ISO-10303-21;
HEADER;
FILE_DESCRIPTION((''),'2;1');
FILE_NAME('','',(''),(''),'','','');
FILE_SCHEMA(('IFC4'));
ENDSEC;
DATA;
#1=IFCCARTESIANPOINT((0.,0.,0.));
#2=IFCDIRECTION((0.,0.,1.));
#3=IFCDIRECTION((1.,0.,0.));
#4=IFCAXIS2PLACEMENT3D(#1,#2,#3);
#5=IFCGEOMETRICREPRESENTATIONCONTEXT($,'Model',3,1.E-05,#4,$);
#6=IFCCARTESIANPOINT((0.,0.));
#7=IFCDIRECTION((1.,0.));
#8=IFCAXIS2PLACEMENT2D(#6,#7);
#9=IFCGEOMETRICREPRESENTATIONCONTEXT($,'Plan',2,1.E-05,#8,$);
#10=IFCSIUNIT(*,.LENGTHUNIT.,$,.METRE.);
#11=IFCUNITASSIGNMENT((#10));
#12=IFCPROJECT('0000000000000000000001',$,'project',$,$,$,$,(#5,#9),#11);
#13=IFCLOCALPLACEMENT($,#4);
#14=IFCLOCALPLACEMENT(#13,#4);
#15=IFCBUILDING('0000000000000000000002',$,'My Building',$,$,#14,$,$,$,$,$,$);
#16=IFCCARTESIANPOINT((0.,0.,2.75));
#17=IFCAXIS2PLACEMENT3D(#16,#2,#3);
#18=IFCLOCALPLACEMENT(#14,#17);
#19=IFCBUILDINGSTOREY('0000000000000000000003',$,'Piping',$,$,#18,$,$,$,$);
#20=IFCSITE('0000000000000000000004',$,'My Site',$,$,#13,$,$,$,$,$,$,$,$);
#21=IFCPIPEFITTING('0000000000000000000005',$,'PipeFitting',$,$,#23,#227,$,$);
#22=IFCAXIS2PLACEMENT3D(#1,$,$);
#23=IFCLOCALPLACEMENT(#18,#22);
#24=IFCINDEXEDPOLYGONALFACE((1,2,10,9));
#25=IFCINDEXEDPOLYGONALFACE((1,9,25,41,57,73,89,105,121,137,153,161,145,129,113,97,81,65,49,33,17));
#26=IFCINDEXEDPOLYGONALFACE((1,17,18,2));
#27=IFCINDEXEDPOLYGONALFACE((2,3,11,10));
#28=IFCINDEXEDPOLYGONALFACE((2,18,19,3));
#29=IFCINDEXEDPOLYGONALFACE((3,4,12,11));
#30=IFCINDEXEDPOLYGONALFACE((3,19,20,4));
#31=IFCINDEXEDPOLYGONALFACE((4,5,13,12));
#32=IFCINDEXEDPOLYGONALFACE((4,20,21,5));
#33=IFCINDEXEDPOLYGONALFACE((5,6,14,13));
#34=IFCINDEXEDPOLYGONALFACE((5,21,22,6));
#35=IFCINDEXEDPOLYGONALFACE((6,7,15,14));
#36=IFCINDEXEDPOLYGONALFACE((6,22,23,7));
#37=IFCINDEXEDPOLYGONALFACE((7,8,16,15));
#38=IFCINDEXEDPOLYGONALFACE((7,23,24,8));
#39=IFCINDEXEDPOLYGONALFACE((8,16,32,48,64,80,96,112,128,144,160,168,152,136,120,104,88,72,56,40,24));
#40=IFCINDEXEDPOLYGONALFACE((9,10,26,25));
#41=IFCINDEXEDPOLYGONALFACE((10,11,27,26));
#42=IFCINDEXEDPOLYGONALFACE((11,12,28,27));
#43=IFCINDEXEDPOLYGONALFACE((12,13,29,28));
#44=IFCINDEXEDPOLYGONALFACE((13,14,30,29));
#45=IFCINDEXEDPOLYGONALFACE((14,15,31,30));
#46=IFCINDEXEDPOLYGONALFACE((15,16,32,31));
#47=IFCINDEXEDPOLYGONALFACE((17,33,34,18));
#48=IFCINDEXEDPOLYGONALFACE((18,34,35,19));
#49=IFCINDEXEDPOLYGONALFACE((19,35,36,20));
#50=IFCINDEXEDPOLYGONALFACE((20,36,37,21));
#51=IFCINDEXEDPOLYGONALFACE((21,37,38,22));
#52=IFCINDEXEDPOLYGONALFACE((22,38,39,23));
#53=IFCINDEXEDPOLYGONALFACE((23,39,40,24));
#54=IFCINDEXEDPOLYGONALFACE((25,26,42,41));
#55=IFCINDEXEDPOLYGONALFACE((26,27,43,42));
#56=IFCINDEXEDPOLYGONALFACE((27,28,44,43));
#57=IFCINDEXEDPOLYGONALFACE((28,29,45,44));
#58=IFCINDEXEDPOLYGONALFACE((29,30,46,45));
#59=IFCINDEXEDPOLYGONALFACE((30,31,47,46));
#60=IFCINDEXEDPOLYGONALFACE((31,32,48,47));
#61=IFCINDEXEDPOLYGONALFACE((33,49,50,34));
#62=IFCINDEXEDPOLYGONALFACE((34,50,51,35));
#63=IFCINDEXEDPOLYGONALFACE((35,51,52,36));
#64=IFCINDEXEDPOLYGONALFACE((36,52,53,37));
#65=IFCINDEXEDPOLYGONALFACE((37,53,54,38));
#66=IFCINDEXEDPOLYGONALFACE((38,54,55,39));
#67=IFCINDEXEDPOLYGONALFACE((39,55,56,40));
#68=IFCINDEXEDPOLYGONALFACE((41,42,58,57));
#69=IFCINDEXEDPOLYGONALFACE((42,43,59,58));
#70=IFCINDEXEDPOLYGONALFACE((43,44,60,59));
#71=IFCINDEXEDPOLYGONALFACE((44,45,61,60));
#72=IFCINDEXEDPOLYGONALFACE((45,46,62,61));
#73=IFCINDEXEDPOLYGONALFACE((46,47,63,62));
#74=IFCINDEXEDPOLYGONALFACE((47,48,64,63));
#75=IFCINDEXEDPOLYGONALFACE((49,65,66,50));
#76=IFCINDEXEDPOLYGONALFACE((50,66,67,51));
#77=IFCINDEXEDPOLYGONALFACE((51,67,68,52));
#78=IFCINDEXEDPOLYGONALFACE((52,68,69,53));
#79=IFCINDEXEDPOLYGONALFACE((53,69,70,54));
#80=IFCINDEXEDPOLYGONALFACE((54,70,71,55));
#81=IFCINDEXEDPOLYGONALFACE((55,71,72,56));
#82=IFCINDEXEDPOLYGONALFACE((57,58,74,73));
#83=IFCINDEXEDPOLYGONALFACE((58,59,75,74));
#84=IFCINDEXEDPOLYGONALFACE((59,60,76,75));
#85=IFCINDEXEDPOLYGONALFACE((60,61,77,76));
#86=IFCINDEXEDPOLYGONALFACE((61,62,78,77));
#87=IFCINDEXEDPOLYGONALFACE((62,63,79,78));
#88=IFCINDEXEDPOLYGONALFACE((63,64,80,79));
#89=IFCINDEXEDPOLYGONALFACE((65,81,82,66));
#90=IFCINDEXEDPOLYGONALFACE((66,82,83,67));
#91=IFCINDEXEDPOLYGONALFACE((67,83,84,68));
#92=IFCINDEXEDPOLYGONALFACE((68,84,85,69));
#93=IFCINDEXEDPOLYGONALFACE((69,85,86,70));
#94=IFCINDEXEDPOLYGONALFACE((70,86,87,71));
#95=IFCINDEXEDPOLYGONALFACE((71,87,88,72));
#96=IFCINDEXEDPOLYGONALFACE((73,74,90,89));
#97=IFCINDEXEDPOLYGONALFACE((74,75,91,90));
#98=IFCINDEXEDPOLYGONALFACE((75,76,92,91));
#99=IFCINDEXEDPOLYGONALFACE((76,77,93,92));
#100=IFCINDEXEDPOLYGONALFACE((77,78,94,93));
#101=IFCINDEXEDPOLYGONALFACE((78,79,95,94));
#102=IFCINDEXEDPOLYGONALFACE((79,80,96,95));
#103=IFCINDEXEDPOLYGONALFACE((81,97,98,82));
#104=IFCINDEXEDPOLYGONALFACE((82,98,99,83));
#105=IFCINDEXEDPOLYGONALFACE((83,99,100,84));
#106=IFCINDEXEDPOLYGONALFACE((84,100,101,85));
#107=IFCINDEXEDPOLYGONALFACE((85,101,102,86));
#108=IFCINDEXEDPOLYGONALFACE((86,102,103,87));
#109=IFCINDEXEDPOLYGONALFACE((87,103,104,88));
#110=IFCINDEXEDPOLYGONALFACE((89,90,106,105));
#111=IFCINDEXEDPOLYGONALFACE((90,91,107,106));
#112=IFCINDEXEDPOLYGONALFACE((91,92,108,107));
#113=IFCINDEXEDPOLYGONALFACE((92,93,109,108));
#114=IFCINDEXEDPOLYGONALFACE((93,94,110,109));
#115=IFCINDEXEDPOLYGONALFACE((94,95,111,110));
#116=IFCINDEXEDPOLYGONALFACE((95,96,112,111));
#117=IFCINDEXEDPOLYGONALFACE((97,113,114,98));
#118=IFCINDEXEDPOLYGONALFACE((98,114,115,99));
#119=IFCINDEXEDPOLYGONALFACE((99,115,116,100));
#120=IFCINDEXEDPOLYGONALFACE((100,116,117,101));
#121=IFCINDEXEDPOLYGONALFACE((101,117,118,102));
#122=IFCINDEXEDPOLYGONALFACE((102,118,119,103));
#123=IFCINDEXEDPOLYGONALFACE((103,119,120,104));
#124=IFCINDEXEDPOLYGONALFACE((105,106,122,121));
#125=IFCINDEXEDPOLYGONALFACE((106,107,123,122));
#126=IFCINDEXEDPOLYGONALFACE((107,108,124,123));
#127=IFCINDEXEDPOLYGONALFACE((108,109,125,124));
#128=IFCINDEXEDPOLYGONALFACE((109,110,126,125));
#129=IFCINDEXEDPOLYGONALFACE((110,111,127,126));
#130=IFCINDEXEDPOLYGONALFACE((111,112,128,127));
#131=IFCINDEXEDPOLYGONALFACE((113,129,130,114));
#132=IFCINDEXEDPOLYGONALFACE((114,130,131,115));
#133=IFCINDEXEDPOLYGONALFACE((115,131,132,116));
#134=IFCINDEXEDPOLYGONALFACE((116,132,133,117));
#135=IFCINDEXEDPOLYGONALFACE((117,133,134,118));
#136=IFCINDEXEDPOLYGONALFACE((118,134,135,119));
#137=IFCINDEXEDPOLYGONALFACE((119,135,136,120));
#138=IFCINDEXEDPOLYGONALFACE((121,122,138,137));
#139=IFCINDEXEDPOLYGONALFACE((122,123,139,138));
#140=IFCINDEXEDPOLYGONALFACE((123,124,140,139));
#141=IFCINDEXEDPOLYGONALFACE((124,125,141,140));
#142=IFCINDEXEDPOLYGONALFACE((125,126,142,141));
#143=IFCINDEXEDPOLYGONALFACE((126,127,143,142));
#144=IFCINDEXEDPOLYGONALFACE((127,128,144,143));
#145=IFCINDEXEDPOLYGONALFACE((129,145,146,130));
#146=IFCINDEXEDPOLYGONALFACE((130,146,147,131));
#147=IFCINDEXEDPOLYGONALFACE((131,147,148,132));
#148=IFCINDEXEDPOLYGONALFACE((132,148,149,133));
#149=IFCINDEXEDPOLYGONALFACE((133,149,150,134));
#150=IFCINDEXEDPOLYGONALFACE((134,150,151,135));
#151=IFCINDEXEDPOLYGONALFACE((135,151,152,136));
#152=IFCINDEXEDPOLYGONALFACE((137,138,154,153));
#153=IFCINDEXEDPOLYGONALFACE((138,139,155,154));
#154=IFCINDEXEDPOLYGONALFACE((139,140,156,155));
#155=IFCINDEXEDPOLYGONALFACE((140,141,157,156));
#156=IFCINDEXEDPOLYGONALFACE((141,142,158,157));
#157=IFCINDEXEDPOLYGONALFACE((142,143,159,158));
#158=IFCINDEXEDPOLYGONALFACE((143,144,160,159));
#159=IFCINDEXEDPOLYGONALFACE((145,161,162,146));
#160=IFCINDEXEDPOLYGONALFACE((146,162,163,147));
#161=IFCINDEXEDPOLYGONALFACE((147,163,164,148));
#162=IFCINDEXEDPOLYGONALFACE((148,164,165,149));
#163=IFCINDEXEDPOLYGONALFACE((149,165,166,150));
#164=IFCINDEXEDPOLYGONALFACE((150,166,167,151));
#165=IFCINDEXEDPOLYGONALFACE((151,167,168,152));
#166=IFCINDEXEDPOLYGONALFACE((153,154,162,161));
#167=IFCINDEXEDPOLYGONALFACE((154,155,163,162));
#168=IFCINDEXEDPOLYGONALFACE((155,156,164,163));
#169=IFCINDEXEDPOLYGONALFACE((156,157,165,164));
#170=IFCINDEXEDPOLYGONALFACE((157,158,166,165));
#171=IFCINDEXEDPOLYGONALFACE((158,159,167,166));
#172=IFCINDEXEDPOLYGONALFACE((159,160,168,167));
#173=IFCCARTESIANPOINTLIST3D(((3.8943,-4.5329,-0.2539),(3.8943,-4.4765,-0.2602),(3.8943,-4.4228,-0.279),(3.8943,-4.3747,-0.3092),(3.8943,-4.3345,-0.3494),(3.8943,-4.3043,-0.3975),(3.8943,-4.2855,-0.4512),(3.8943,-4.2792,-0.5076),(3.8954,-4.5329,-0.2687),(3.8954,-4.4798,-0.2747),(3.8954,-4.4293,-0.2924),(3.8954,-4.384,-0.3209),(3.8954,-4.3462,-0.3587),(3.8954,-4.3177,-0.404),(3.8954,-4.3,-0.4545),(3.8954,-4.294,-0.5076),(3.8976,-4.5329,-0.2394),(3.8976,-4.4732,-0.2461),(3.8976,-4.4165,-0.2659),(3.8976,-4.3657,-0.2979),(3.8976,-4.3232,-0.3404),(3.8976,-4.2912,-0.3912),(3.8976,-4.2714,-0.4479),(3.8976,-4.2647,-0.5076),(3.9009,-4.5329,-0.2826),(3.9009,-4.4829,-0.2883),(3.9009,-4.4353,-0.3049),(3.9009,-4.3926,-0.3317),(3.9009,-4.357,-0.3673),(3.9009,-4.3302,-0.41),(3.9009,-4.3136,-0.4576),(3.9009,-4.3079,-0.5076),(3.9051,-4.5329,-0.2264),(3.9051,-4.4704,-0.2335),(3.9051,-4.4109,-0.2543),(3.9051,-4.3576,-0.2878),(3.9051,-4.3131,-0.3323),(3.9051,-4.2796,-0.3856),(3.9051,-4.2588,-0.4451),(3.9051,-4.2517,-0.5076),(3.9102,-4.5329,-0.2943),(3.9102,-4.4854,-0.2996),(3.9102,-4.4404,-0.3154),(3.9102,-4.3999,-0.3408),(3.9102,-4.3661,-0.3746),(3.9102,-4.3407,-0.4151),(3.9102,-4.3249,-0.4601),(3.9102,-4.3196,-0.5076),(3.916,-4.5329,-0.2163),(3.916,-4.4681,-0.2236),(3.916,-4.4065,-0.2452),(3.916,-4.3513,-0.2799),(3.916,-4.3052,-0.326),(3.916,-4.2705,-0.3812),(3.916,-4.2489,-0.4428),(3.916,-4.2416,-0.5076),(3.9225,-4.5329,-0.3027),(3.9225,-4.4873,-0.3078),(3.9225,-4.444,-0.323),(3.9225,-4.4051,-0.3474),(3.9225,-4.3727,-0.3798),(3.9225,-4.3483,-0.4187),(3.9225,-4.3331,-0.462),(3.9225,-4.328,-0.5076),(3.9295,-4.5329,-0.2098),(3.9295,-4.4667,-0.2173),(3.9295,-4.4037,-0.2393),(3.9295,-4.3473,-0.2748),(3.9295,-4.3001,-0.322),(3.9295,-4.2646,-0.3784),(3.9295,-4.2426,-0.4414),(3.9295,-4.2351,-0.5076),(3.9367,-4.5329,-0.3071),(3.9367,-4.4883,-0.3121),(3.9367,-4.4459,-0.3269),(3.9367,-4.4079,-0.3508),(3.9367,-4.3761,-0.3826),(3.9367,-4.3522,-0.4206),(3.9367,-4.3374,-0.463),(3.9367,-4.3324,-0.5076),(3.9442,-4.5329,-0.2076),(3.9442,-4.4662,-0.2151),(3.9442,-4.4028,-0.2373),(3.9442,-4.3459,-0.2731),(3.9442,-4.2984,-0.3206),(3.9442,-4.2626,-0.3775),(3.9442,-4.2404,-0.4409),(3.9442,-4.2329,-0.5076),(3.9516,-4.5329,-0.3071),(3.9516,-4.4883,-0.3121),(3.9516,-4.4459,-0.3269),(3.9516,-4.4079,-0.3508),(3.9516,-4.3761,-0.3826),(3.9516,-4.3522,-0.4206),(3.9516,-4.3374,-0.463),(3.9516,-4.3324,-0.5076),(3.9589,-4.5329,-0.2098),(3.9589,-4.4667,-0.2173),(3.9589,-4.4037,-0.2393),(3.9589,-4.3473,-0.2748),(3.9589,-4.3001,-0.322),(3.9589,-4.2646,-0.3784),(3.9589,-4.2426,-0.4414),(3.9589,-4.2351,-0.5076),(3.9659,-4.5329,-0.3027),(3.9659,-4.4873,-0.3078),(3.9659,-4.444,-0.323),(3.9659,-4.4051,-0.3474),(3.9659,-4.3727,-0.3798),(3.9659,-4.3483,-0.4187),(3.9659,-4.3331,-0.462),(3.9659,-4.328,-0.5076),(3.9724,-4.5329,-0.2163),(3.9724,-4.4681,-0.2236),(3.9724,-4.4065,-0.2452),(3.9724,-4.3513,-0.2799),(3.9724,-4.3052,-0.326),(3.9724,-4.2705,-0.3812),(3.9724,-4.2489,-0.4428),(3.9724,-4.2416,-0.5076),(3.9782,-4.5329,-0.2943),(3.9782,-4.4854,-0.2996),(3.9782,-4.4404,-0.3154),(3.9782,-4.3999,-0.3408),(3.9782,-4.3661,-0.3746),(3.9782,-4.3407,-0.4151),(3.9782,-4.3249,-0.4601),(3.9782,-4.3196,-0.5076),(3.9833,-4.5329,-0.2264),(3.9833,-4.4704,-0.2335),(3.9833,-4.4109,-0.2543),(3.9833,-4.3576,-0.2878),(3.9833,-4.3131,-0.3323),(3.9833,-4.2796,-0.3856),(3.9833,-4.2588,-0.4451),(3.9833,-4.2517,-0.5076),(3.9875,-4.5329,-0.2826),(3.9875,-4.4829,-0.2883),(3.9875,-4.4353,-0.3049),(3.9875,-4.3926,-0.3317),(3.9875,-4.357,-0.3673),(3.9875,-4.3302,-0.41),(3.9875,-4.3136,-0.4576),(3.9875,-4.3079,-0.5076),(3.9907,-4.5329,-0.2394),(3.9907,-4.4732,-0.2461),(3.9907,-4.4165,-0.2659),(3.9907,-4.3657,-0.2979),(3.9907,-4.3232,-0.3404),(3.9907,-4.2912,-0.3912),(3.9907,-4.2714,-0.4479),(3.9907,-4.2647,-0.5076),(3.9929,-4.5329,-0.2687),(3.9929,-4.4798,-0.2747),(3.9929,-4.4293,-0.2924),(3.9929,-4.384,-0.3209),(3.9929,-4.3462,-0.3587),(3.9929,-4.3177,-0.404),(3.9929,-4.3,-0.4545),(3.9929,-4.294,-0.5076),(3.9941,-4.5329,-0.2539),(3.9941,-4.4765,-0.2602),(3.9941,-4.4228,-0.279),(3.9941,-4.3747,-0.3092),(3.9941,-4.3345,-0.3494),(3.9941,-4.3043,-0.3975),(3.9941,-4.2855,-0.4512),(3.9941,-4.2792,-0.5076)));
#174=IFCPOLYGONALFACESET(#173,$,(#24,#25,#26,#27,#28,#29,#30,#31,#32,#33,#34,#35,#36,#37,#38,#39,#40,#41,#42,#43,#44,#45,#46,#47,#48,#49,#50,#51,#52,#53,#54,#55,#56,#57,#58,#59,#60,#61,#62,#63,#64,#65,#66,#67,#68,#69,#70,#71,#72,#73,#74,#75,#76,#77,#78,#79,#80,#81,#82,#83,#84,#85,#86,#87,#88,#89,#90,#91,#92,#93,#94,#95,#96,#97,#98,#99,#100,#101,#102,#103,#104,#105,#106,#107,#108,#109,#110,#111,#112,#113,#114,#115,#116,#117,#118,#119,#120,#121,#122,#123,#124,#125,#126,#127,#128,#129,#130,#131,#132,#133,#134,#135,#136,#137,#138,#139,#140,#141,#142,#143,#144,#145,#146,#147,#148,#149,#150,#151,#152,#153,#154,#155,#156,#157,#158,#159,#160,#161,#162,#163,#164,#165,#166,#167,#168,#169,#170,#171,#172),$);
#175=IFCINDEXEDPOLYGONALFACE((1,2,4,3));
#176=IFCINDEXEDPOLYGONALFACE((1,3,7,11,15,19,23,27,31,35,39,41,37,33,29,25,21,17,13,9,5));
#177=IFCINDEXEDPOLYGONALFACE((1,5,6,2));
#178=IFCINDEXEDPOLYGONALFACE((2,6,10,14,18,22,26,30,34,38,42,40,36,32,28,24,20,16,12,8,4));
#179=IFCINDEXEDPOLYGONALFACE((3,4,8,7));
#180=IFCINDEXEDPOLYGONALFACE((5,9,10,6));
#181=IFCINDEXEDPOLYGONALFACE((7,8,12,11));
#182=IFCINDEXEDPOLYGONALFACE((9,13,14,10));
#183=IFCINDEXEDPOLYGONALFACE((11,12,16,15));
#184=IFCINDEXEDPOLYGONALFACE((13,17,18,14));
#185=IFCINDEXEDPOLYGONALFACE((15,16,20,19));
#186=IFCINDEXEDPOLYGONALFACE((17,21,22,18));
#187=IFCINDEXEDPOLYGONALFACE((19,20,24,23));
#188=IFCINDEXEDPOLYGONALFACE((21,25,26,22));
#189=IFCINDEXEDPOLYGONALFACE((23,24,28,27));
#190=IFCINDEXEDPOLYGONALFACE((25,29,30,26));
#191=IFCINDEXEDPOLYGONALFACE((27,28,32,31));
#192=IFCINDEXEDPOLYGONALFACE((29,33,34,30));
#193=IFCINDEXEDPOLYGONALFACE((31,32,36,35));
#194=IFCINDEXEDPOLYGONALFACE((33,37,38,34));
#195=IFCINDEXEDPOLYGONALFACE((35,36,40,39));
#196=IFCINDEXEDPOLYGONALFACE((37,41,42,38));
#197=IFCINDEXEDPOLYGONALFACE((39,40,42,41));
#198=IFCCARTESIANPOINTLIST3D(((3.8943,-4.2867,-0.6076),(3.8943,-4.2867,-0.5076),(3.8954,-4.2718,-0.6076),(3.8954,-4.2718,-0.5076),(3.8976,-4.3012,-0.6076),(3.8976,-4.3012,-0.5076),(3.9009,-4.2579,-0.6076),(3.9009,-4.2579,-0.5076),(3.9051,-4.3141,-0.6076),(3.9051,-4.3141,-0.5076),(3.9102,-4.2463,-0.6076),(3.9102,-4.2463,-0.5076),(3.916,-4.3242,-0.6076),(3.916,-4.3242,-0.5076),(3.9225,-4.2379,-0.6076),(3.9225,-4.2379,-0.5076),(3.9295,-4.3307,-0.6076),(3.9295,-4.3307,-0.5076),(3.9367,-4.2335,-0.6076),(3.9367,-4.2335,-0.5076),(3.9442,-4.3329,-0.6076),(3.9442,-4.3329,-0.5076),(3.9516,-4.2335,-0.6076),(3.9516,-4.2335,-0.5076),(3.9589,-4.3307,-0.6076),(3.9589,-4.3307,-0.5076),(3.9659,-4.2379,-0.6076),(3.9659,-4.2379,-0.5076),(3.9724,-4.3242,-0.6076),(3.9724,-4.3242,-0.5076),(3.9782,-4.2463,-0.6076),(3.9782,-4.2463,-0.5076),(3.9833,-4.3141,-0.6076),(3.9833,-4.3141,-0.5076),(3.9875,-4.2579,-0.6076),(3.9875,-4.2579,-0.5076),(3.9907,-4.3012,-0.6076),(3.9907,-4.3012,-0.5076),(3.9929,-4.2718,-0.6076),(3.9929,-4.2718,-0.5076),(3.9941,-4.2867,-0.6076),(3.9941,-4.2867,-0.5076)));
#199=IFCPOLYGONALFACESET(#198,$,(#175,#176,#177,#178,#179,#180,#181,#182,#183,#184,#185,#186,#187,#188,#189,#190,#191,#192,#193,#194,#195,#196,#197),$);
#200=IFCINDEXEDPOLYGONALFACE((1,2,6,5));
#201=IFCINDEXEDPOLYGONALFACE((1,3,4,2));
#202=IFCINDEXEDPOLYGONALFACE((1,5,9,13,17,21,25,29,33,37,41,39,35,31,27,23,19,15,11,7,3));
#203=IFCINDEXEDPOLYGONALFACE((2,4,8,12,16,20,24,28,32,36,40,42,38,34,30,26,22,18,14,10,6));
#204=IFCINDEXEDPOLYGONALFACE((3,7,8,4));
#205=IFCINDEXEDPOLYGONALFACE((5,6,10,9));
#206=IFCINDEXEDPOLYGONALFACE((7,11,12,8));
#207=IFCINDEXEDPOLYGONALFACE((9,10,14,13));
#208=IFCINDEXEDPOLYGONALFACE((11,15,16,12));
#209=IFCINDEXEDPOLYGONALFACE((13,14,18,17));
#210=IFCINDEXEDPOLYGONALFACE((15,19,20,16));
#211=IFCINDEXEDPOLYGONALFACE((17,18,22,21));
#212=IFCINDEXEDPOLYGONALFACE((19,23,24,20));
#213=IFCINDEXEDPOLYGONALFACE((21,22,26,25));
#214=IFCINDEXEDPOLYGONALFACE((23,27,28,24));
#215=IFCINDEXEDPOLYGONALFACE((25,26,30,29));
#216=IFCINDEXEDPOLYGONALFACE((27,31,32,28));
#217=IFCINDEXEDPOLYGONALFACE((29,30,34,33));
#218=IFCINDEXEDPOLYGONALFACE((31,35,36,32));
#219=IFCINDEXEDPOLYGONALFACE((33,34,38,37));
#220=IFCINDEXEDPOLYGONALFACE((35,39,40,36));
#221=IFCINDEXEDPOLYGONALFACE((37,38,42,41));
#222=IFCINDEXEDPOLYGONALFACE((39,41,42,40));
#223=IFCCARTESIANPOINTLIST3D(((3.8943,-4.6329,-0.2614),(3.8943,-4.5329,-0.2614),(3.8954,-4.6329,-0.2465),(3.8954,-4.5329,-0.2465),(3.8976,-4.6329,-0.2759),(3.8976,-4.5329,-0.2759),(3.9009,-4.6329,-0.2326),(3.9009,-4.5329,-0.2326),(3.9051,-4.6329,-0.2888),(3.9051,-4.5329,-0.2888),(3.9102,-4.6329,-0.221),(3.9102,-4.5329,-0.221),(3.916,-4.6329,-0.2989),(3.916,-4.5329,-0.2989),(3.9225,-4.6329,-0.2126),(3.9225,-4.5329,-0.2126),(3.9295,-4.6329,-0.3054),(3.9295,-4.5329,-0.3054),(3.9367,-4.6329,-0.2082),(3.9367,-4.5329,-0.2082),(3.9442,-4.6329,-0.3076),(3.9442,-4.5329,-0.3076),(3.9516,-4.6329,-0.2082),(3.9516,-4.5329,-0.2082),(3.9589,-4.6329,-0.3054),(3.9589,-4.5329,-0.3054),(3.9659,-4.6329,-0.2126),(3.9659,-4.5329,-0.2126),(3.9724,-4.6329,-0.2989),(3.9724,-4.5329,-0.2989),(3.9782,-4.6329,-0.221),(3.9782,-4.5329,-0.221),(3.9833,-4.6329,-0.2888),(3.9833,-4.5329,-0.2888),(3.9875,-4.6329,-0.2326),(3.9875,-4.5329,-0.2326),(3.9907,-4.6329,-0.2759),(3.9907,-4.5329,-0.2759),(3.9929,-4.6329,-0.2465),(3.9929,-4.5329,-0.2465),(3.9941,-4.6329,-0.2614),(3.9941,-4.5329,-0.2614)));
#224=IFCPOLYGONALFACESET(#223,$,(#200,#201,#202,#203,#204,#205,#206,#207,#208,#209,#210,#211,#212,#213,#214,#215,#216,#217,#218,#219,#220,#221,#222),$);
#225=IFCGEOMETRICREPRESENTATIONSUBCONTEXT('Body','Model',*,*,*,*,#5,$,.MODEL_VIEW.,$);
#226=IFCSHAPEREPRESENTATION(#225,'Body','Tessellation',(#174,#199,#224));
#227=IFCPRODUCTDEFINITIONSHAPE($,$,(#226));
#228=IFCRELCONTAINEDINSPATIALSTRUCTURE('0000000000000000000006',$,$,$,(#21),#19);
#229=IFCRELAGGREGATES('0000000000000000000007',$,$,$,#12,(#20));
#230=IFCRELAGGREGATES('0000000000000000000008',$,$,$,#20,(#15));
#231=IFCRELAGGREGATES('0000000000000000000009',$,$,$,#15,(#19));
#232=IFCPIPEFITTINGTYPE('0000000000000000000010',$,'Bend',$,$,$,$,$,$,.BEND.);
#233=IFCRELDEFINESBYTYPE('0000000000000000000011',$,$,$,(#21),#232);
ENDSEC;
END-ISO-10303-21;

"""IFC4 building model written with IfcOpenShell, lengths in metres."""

from ifc_helpers import new_model, entity, si_unit, frame, origin_with_axes, origin_2d_with_axis, place, context, subcontext, project, spatial, circle, extrude, source, transform, mapped, type_object, type_shapes, element, save


model = new_model("IFC4")

# Units and contexts
model_context = context("Model", 3, precision=1e-05, world=origin_with_axes())
plan_context = context("Plan", 2, precision=1e-05, world=origin_2d_with_axis())
body_context = subcontext(model_context, "Body", "Model", "MODEL_VIEW")
ifc_project = project(units=[si_unit("LENGTHUNIT", "METRE")], contexts=[model_context, plan_context])

# Site, building, storey
site_placement = place(None, origin_with_axes())
site = spatial("IfcSite", under=ifc_project, at=site_placement, Name="My Site")
building_placement = place(site_placement, origin_with_axes())
building = spatial("IfcBuilding", under=site, at=building_placement, Name="My Building")
storey_placement = place(building_placement, frame((0.0, 0.0, 2.75), z_axis=(0.0, 0.0, 1.0), x_axis=(1.0, 0.0, 0.0)))
storey = spatial("IfcBuildingStorey", under=building, at=storey_placement, Name="Piping")

# Pipe fitting
pipe_fitting_type = type_object("IfcPipeFittingType", Name="Bend", PredefinedType="BEND")
shared_shape = source(origin_with_axes(), body_context, "Body", "SolidModel", [
    entity("IfcSweptDiskSolid", entity("IfcIndexedPolyCurve", entity("IfcCartesianPointList3D", [[0.0, 0.0, -0.1], [0.0732, 0.0, -0.2768], [0.25, 0.0, -0.35]]), [entity("IfcArcIndex", [1, 2, 3])]), 0.05),
    extrude(circle(Radius=0.05), origin_with_axes(), (0.0, 0.0, -1.0), 0.1),
    extrude(circle(Radius=0.05), frame((0.25, 0.0, -0.35), z_axis=(1.0, 0.0, 0.0), x_axis=(0.0, 0.0, 1.0)), (0.0, 0.0, 1.0), 0.1),
])
type_shapes(pipe_fitting_type, [shared_shape])
for number, where, z_axis, x_axis, name in (
    (1, (3.9442, -4.2829, -0.6076), (0.0, 0.0, -1.0), (0.0, -1.0, 0.0), "PipeFitting"),
):
    element("IfcPipeFitting", number, at=place(storey_placement, frame(where, z_axis=z_axis, x_axis=x_axis)), inside=storey, type_object=pipe_fitting_type, Name=name, context=body_context, shape_type="MappedRepresentation", body=[
        mapped(shared_shape, transform((0.0, 0.0, 0.0), x_axis=(1.0, 0.0, 0.0), y_axis=(0.0, 1.0, 0.0), z_axis=(0.0, 0.0, 1.0), scale=1.0)),
    ])

save(model, "model.ifc")
